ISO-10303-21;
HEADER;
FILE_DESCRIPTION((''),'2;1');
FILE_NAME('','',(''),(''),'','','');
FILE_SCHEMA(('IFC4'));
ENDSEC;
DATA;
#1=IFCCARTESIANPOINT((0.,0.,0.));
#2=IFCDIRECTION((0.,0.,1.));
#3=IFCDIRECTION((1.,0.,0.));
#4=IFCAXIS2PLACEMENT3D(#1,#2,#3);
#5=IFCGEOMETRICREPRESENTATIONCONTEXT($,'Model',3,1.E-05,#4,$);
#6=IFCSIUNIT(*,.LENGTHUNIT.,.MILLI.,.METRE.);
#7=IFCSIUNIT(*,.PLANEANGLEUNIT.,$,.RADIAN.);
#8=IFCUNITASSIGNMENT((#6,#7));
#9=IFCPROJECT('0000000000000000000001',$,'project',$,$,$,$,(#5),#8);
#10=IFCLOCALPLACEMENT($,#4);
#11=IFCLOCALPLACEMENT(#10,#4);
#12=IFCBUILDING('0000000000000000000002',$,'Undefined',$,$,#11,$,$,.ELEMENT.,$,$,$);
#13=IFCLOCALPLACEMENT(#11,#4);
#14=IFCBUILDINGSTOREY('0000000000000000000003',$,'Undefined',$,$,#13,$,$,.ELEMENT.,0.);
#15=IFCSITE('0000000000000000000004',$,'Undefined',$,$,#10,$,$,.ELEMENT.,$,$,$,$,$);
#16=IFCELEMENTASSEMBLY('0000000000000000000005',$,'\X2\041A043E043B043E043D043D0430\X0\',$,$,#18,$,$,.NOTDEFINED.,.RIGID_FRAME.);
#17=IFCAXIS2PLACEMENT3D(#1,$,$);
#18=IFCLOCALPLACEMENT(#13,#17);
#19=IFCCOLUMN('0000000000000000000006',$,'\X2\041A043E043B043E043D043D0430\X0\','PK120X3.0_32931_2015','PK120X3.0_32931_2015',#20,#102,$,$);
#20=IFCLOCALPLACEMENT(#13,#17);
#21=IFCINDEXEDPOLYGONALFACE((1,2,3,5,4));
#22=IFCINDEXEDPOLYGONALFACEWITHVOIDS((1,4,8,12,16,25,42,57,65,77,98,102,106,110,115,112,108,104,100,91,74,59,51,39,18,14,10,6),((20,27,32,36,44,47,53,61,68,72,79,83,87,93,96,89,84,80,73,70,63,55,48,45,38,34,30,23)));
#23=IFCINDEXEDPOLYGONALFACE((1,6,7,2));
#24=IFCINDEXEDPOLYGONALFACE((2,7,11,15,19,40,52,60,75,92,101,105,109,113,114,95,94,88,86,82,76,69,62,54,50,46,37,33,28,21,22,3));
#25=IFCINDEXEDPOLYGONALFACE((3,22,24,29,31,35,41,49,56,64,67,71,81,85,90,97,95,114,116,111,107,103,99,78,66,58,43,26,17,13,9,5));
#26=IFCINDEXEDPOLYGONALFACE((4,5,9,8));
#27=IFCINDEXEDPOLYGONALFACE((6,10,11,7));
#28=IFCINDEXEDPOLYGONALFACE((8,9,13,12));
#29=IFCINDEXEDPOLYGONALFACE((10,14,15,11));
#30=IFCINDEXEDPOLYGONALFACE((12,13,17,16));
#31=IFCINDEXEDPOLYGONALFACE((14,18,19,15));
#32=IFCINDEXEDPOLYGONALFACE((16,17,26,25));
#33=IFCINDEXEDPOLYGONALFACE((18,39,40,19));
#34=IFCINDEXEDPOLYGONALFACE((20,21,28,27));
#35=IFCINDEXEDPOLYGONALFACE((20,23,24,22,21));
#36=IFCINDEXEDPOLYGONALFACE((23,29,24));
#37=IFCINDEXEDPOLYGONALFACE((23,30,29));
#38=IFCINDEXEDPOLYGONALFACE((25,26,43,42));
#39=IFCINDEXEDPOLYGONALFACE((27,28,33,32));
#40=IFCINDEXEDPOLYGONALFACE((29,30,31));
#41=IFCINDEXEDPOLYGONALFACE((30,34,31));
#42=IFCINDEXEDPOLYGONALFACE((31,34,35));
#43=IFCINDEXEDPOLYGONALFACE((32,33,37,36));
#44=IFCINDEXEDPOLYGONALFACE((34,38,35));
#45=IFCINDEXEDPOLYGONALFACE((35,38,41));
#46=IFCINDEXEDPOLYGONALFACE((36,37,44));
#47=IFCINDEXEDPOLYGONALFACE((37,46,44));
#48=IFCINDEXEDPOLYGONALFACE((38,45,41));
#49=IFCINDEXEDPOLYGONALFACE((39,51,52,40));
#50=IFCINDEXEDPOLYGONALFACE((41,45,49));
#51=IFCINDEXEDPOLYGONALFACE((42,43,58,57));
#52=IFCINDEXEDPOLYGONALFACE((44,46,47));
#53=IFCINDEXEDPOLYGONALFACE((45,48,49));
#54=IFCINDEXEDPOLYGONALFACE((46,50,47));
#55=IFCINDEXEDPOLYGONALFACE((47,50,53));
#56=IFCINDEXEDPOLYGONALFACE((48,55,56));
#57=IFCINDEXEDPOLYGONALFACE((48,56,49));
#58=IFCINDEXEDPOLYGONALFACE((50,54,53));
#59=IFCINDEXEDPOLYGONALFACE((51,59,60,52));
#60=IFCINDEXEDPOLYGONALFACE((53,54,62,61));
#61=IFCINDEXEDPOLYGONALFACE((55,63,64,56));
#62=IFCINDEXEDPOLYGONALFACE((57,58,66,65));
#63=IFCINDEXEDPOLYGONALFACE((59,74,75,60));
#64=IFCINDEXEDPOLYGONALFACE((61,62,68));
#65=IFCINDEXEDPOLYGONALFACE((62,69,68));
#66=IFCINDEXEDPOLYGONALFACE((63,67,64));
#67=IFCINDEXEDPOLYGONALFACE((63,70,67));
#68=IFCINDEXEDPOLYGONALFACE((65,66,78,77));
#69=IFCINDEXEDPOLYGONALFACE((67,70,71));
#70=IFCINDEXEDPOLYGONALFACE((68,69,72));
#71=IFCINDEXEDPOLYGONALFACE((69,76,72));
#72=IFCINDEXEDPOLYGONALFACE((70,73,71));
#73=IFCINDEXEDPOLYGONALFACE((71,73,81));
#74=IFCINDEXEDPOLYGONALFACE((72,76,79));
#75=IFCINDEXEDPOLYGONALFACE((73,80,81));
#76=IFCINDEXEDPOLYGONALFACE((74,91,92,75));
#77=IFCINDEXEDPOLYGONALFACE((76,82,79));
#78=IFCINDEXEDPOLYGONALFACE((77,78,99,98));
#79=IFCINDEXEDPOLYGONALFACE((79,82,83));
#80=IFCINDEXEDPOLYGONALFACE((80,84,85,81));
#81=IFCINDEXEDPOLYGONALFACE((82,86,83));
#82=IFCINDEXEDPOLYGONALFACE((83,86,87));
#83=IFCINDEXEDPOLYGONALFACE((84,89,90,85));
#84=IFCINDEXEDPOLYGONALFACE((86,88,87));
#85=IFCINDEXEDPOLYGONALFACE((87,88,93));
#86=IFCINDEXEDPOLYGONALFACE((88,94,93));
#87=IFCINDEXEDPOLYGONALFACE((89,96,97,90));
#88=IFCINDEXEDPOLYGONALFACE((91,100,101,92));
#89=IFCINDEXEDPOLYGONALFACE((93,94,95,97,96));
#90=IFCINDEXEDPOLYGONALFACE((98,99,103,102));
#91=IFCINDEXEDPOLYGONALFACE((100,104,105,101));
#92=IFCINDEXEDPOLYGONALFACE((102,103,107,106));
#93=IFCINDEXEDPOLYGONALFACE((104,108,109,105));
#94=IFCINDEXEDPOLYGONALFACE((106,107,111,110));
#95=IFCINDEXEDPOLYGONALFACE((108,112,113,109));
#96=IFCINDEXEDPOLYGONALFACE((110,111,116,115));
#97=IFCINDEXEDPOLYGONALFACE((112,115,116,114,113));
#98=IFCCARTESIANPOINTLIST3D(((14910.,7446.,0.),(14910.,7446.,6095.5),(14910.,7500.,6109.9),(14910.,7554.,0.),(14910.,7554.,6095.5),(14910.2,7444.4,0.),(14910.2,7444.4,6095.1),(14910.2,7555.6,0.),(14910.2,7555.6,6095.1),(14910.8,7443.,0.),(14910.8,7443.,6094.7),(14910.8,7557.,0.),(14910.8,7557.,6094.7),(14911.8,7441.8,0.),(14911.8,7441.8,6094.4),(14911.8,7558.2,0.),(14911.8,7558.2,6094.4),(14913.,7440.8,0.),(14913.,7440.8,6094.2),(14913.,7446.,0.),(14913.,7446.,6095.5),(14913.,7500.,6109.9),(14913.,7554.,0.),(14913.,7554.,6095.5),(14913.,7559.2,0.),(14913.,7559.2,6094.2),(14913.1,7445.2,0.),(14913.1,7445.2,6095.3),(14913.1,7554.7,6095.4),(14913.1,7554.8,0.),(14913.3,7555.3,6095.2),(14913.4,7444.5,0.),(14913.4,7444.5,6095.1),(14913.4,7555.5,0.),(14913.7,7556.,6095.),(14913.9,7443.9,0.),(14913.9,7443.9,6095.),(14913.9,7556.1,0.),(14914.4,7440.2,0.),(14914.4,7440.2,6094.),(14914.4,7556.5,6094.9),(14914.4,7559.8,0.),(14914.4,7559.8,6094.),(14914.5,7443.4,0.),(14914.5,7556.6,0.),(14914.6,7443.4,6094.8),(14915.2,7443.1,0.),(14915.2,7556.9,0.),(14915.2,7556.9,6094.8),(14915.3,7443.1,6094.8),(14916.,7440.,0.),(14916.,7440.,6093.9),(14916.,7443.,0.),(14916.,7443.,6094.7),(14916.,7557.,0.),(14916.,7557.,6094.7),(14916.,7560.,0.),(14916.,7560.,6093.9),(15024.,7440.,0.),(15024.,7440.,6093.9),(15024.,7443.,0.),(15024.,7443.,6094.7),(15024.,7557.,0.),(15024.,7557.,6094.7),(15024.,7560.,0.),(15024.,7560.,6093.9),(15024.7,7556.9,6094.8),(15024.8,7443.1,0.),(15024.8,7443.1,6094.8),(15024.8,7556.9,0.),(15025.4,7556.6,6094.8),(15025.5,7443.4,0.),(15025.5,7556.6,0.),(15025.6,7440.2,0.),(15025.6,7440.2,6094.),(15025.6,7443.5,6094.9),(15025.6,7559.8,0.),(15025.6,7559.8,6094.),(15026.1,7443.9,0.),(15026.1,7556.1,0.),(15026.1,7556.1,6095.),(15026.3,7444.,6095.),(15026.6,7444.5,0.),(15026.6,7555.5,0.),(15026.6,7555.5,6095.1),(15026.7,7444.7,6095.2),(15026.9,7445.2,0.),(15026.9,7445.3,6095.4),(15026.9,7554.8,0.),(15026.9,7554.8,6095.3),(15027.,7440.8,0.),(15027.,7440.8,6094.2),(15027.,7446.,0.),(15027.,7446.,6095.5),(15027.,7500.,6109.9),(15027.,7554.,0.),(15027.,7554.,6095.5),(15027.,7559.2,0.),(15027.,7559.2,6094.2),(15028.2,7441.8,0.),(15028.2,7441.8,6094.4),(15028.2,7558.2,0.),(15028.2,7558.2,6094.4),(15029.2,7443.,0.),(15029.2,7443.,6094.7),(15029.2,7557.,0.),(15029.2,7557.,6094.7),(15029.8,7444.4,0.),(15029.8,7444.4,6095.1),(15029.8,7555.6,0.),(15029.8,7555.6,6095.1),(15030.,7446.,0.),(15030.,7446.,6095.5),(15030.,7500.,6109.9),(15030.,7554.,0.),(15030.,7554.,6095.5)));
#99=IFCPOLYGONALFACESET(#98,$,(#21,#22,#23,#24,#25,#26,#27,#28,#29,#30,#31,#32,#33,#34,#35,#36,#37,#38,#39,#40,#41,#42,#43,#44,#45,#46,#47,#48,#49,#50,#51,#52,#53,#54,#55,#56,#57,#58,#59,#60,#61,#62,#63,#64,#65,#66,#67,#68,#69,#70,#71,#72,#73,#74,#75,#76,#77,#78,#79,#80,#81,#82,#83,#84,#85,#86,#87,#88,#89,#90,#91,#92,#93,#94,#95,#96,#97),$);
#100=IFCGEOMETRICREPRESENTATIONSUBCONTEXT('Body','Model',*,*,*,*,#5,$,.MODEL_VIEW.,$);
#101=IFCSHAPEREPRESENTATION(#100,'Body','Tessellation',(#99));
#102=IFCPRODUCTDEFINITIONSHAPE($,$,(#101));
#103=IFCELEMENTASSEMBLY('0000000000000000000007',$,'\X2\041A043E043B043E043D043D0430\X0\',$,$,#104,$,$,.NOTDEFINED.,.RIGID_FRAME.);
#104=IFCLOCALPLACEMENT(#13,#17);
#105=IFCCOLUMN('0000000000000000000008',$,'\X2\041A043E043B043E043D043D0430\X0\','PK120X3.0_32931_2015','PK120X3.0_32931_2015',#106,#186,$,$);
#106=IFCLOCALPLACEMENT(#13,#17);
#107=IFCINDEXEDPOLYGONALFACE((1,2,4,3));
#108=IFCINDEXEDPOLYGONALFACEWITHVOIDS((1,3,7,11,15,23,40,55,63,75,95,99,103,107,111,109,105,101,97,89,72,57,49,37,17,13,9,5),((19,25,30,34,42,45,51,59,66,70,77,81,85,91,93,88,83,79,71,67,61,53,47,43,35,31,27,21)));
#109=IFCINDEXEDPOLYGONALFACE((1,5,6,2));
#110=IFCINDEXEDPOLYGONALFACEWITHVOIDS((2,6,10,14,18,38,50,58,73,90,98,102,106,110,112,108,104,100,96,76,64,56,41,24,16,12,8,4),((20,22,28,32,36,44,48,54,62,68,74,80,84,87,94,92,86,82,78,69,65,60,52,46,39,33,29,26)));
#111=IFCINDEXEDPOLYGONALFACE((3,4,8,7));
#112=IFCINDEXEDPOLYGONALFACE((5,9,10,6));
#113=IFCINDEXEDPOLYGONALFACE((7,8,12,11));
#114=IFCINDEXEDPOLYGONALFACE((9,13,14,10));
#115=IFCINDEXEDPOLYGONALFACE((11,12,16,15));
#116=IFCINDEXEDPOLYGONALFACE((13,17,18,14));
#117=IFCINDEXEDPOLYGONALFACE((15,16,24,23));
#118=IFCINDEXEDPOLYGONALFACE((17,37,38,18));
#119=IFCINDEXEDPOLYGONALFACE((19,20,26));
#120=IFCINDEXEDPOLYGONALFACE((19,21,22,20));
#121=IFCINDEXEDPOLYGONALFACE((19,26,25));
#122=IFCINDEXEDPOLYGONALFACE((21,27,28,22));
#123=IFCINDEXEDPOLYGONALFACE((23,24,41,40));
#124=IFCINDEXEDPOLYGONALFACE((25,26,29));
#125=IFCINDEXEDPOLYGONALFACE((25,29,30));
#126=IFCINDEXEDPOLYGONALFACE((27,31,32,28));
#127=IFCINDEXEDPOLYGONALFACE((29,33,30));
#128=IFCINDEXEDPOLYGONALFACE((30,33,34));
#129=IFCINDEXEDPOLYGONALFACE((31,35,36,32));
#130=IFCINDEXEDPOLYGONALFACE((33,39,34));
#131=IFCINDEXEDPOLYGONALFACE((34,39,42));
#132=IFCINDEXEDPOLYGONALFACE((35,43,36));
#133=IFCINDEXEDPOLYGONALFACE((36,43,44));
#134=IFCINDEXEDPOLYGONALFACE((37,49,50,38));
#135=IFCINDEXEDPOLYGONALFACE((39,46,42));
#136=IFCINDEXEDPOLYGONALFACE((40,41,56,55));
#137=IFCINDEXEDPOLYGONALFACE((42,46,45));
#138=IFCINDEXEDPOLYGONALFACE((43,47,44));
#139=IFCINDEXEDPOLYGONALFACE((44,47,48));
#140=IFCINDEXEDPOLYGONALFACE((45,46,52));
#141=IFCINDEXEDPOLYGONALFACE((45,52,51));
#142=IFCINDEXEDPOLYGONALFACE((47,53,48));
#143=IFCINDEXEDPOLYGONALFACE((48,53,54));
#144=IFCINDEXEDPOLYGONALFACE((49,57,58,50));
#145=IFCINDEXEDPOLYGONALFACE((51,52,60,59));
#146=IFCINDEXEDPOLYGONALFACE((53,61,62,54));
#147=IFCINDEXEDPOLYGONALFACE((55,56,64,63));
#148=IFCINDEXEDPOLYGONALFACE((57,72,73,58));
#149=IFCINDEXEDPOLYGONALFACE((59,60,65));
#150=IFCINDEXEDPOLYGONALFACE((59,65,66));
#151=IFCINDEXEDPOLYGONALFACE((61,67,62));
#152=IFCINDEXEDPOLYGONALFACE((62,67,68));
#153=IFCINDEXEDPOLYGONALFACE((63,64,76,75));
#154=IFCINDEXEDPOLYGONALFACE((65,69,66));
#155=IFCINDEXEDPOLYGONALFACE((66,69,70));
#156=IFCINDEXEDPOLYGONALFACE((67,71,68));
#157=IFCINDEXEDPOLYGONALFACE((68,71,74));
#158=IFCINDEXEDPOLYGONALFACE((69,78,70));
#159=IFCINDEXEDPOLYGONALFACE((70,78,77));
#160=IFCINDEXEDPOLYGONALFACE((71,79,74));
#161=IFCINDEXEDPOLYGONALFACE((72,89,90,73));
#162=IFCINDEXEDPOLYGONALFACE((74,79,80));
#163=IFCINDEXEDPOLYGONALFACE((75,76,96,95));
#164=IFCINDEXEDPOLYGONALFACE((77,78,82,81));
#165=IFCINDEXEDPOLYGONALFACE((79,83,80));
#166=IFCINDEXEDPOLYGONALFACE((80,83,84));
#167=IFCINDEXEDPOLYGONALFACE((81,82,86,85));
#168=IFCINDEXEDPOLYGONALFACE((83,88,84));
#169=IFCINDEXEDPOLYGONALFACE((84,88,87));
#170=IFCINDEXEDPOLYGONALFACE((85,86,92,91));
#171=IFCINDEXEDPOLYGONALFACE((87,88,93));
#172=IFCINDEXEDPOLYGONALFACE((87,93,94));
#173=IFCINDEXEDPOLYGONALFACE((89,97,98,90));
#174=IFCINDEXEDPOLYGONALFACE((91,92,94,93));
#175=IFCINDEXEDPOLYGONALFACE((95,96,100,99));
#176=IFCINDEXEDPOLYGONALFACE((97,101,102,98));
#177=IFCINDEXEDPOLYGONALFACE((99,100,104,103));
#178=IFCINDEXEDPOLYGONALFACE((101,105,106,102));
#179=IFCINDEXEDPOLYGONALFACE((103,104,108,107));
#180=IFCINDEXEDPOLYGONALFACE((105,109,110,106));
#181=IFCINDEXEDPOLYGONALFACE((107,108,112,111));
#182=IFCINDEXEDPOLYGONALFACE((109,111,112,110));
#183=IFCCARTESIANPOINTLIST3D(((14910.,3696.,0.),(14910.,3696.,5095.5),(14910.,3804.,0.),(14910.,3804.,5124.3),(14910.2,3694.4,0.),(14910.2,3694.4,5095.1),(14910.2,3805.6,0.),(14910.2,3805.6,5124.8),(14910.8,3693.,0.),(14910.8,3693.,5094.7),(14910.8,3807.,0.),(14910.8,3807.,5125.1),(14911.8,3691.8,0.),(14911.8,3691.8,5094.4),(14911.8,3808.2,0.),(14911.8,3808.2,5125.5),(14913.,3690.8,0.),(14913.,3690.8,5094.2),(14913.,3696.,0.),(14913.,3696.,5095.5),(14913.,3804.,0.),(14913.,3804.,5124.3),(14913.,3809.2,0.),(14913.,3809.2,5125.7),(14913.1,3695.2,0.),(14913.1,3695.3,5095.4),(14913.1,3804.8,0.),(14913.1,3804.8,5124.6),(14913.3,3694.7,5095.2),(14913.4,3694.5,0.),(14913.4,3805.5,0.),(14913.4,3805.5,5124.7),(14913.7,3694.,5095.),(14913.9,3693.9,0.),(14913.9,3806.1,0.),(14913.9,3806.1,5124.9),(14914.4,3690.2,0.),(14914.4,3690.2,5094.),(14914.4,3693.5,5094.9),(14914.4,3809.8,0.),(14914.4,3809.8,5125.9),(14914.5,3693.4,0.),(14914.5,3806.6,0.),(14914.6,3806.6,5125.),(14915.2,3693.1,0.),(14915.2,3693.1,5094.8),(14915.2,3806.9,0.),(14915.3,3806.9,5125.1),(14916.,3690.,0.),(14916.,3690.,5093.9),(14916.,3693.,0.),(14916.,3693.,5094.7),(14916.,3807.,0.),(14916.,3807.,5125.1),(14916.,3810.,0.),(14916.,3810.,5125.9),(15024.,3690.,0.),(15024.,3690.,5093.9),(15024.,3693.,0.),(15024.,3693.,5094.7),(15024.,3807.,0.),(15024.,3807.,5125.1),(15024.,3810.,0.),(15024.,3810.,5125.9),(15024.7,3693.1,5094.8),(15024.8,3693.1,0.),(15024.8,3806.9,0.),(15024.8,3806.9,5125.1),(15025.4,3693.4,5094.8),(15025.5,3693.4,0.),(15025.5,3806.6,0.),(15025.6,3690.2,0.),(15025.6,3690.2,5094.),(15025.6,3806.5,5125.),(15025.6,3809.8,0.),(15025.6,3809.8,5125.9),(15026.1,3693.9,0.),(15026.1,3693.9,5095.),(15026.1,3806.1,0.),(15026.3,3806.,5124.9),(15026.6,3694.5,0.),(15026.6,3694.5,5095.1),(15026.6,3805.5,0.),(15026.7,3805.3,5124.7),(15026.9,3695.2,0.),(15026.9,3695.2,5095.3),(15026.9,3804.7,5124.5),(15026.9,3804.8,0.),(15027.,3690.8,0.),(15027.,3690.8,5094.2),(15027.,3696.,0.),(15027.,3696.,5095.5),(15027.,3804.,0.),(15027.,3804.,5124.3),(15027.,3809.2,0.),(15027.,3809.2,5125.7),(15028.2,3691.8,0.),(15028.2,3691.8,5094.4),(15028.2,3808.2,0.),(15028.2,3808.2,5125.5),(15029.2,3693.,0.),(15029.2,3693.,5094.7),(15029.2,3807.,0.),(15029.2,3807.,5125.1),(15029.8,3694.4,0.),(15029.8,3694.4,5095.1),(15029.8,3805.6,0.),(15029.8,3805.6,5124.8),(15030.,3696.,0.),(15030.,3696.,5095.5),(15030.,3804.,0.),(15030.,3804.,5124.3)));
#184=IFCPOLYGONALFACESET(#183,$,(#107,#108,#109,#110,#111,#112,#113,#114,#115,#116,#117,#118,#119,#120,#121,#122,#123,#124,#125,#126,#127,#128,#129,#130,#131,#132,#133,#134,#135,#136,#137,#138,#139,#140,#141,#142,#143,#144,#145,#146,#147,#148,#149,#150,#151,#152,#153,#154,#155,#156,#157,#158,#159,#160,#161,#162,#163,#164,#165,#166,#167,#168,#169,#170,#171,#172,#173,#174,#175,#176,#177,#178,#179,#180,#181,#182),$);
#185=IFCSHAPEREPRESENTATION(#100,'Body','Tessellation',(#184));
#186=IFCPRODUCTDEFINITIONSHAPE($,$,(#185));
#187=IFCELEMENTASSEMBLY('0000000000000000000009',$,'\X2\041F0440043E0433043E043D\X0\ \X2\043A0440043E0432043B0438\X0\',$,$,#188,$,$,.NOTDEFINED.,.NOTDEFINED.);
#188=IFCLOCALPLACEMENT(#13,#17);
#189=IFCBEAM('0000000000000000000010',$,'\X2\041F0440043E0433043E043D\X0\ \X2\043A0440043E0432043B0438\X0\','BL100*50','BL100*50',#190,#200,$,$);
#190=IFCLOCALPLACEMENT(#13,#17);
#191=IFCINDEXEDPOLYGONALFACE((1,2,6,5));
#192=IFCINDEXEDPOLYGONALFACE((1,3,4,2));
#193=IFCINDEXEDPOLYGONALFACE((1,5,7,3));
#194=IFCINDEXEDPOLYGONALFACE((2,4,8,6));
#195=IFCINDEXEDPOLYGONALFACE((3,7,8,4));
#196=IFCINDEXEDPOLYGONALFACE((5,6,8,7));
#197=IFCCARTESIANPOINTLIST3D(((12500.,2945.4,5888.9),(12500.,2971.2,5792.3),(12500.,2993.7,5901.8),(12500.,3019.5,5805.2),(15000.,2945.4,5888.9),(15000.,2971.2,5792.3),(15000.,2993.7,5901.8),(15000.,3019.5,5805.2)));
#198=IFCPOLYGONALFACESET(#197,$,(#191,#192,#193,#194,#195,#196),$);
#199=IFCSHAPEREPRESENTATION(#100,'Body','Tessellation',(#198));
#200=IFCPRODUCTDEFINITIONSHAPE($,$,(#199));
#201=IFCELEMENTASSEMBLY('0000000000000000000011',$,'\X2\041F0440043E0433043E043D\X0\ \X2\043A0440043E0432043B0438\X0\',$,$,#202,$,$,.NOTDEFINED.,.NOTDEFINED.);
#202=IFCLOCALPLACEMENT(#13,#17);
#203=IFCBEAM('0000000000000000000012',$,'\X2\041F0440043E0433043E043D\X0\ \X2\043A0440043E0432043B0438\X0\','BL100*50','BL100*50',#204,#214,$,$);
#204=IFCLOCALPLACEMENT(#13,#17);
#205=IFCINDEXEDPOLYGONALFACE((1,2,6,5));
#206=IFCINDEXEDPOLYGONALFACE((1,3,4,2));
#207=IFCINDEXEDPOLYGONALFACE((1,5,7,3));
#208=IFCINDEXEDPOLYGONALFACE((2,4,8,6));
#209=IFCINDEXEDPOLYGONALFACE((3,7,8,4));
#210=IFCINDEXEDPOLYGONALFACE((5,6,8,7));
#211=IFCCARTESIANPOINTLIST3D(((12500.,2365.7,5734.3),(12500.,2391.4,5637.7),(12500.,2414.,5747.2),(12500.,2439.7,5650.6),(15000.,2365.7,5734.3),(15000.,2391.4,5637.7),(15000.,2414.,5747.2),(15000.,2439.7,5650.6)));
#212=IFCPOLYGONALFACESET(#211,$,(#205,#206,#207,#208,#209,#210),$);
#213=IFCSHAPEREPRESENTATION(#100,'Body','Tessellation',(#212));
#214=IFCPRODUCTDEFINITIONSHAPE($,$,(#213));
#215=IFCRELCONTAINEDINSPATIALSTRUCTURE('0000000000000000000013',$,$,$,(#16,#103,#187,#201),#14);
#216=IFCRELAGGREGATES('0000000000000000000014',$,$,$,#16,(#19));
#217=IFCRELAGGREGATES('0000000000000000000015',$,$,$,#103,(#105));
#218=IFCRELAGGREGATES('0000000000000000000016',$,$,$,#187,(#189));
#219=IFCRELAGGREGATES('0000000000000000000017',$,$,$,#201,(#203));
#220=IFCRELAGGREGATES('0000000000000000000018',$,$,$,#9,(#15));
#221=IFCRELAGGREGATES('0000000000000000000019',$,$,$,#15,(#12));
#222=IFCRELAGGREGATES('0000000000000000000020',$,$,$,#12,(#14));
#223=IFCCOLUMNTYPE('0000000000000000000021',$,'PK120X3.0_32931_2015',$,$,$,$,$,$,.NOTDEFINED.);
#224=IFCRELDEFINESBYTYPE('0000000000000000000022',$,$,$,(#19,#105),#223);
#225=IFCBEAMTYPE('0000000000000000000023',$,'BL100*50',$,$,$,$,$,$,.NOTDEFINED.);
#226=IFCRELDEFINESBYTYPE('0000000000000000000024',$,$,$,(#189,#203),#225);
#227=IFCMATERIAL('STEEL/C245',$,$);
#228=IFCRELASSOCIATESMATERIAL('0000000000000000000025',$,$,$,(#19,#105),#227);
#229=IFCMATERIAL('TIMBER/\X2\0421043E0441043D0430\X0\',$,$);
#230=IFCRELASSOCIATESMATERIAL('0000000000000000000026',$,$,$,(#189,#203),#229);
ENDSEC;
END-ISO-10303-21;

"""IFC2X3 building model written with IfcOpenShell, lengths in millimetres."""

from ifc_helpers import new_model, si_unit, frame, origin_with_axes, origin_2d_with_axis, place, context, subcontext, project, spatial, rectangle, hollow_rectangle, extrude, clip, halfspace, material, type_object, element, aggregate, save


model = new_model("IFC2X3")

# Units and contexts
model_context = context("Model", 3, precision=1e-05, world=origin_with_axes())
body_context = subcontext(model_context, "Body", "Model", "MODEL_VIEW")
ifc_project = project(units=[si_unit("LENGTHUNIT", "METRE", prefix="MILLI"), si_unit("PLANEANGLEUNIT", "RADIAN")], contexts=[model_context])

# Site, building, storey
site_placement = place(None, origin_with_axes())
site = spatial("IfcSite", under=ifc_project, at=site_placement, Name="Undefined", CompositionType="ELEMENT")
building_placement = place(site_placement, origin_with_axes())
building = spatial("IfcBuilding", under=site, at=building_placement, Name="Undefined", CompositionType="ELEMENT")
storey_placement = place(building_placement, origin_with_axes())
storey = spatial("IfcBuildingStorey", under=building, at=storey_placement, Name="Undefined", CompositionType="ELEMENT", Elevation=0.0)

# Element assemblies, columns
assembly_1_placement = place(storey_placement, origin_with_axes())
assembly_1 = element("IfcElementAssembly", 1, at=assembly_1_placement, inside=storey, Name="Колонна", AssemblyPlace="NOTDEFINED", PredefinedType="RIGID_FRAME")
ifc_material_1 = material(Name="STEEL/C245")
column_type = type_object("IfcColumnType", Name="PK120X3.0_32931_2015", PredefinedType="NOTDEFINED")
column_1_placement = place(assembly_1_placement, frame((14970.0, 7500.0, 0.0), z_axis=(0.0, 0.0, 1.0), x_axis=(0.0, 1.0, 0.0)))
column_1 = element("IfcColumn", 2, at=column_1_placement, type_object=column_type, material=ifc_material_1, Name="Колонна", Description="PK120X3.0_32931_2015", ObjectType="PK120X3.0_32931_2015", context=body_context, shape_type="Clipping", body=[
    clip(clip(extrude(hollow_rectangle(XDim=120.0, YDim=120.0, WallThickness=3.0, InnerFilletRadius=3.0, OuterFilletRadius=6.0, at=origin_2d_with_axis()), frame((0.0, 0.0, 6109.9), z_axis=(0.0, 0.0, -1.0), x_axis=(0.0, 1.0, 0.0)), (0.0, 0.0, 1.0), 6109.9), halfspace(frame((-60.0, -90.0, 6125.9), z_axis=(0.257663, 0.0, 0.966235), x_axis=(0.0, 1.0, 0.0)), False)), halfspace(frame((-112.5, -30.0, 6079.9), z_axis=(-0.257663, 0.0, 0.966235), x_axis=(-0.966235, 0.0, -0.257663)), False)),
])
aggregate(assembly_1, [column_1])
assembly_2_placement = place(storey_placement, origin_with_axes())
assembly_2 = element("IfcElementAssembly", 3, at=assembly_2_placement, inside=storey, Name="Колонна", AssemblyPlace="NOTDEFINED", PredefinedType="RIGID_FRAME")
column_2_placement = place(assembly_2_placement, frame((14970.0, 3750.0, 0.0), z_axis=(0.0, 0.0, 1.0), x_axis=(0.0, 1.0, 0.0)))
column_2 = element("IfcColumn", 4, at=column_2_placement, type_object=column_type, material=ifc_material_1, Name="Колонна", Description="PK120X3.0_32931_2015", ObjectType="PK120X3.0_32931_2015", context=body_context, shape_type="Clipping", body=[
    clip(extrude(hollow_rectangle(XDim=120.0, YDim=120.0, WallThickness=3.0, InnerFilletRadius=3.0, OuterFilletRadius=6.0, at=origin_2d_with_axis()), frame((0.0, 0.0, 5126.1), z_axis=(0.0, 0.0, -1.0), x_axis=(0.0, 1.0, 0.0)), (0.0, 0.0, 1.0), 5126.1), halfspace(frame((-100.8, -30.0, 5083.1), z_axis=(0.257663, 0.0, -0.966235), x_axis=(0.966235, 0.0, 0.257663)), True)),
])
aggregate(assembly_2, [column_2])

# Element assemblies, beams
assembly_3_placement = place(storey_placement, origin_with_axes())
assembly_3 = element("IfcElementAssembly", 5, at=assembly_3_placement, inside=storey, Name="Прогон кровли", AssemblyPlace="NOTDEFINED", PredefinedType="NOTDEFINED")
ifc_material_2 = material(Name="TIMBER/Сосна")
beam_type_1 = type_object("IfcBeamType", Name="BL100*50", PredefinedType="NOTDEFINED")
beam_1_placement = place(assembly_3_placement, frame((12500.0, 2982.4, 5847.1), z_axis=(0.0, 0.257663, -0.966235), x_axis=(1.0, 0.0, 0.0)))
beam_1 = element("IfcBeam", 6, at=beam_1_placement, type_object=beam_type_1, material=ifc_material_2, Name="Прогон кровли", Description="BL100*50", ObjectType="BL100*50", context=body_context, shape_type="SweptSolid", body=[
    extrude(rectangle(XDim=50.0, YDim=100.0, at=origin_2d_with_axis()), frame((2500.0, 0.0, 0.0), z_axis=(-1.0, 0.0, 0.0), x_axis=(0.0, -1.0, 0.0)), (0.0, 0.0, 1.0), 2500.0),
])
aggregate(assembly_3, [beam_1])
assembly_4_placement = place(storey_placement, origin_with_axes())
assembly_4 = element("IfcElementAssembly", 7, at=assembly_4_placement, inside=storey, Name="Прогон кровли", AssemblyPlace="NOTDEFINED", PredefinedType="NOTDEFINED")
beam_2_placement = place(assembly_4_placement, frame((12500.0, 2402.7, 5692.5), z_axis=(0.0, 0.257663, -0.966235), x_axis=(1.0, 0.0, 0.0)))
beam_2 = element("IfcBeam", 8, at=beam_2_placement, type_object=beam_type_1, material=ifc_material_2, Name="Прогон кровли", Description="BL100*50", ObjectType="BL100*50", context=body_context, shape_type="SweptSolid", body=[
    extrude(rectangle(XDim=50.0, YDim=100.0, at=origin_2d_with_axis()), frame((2500.0, 0.0, 0.0), z_axis=(-1.0, 0.0, 0.0), x_axis=(0.0, -1.0, 0.0)), (0.0, 0.0, 1.0), 2500.0),
])
aggregate(assembly_4, [beam_2])

save(model, "model.ifc")
